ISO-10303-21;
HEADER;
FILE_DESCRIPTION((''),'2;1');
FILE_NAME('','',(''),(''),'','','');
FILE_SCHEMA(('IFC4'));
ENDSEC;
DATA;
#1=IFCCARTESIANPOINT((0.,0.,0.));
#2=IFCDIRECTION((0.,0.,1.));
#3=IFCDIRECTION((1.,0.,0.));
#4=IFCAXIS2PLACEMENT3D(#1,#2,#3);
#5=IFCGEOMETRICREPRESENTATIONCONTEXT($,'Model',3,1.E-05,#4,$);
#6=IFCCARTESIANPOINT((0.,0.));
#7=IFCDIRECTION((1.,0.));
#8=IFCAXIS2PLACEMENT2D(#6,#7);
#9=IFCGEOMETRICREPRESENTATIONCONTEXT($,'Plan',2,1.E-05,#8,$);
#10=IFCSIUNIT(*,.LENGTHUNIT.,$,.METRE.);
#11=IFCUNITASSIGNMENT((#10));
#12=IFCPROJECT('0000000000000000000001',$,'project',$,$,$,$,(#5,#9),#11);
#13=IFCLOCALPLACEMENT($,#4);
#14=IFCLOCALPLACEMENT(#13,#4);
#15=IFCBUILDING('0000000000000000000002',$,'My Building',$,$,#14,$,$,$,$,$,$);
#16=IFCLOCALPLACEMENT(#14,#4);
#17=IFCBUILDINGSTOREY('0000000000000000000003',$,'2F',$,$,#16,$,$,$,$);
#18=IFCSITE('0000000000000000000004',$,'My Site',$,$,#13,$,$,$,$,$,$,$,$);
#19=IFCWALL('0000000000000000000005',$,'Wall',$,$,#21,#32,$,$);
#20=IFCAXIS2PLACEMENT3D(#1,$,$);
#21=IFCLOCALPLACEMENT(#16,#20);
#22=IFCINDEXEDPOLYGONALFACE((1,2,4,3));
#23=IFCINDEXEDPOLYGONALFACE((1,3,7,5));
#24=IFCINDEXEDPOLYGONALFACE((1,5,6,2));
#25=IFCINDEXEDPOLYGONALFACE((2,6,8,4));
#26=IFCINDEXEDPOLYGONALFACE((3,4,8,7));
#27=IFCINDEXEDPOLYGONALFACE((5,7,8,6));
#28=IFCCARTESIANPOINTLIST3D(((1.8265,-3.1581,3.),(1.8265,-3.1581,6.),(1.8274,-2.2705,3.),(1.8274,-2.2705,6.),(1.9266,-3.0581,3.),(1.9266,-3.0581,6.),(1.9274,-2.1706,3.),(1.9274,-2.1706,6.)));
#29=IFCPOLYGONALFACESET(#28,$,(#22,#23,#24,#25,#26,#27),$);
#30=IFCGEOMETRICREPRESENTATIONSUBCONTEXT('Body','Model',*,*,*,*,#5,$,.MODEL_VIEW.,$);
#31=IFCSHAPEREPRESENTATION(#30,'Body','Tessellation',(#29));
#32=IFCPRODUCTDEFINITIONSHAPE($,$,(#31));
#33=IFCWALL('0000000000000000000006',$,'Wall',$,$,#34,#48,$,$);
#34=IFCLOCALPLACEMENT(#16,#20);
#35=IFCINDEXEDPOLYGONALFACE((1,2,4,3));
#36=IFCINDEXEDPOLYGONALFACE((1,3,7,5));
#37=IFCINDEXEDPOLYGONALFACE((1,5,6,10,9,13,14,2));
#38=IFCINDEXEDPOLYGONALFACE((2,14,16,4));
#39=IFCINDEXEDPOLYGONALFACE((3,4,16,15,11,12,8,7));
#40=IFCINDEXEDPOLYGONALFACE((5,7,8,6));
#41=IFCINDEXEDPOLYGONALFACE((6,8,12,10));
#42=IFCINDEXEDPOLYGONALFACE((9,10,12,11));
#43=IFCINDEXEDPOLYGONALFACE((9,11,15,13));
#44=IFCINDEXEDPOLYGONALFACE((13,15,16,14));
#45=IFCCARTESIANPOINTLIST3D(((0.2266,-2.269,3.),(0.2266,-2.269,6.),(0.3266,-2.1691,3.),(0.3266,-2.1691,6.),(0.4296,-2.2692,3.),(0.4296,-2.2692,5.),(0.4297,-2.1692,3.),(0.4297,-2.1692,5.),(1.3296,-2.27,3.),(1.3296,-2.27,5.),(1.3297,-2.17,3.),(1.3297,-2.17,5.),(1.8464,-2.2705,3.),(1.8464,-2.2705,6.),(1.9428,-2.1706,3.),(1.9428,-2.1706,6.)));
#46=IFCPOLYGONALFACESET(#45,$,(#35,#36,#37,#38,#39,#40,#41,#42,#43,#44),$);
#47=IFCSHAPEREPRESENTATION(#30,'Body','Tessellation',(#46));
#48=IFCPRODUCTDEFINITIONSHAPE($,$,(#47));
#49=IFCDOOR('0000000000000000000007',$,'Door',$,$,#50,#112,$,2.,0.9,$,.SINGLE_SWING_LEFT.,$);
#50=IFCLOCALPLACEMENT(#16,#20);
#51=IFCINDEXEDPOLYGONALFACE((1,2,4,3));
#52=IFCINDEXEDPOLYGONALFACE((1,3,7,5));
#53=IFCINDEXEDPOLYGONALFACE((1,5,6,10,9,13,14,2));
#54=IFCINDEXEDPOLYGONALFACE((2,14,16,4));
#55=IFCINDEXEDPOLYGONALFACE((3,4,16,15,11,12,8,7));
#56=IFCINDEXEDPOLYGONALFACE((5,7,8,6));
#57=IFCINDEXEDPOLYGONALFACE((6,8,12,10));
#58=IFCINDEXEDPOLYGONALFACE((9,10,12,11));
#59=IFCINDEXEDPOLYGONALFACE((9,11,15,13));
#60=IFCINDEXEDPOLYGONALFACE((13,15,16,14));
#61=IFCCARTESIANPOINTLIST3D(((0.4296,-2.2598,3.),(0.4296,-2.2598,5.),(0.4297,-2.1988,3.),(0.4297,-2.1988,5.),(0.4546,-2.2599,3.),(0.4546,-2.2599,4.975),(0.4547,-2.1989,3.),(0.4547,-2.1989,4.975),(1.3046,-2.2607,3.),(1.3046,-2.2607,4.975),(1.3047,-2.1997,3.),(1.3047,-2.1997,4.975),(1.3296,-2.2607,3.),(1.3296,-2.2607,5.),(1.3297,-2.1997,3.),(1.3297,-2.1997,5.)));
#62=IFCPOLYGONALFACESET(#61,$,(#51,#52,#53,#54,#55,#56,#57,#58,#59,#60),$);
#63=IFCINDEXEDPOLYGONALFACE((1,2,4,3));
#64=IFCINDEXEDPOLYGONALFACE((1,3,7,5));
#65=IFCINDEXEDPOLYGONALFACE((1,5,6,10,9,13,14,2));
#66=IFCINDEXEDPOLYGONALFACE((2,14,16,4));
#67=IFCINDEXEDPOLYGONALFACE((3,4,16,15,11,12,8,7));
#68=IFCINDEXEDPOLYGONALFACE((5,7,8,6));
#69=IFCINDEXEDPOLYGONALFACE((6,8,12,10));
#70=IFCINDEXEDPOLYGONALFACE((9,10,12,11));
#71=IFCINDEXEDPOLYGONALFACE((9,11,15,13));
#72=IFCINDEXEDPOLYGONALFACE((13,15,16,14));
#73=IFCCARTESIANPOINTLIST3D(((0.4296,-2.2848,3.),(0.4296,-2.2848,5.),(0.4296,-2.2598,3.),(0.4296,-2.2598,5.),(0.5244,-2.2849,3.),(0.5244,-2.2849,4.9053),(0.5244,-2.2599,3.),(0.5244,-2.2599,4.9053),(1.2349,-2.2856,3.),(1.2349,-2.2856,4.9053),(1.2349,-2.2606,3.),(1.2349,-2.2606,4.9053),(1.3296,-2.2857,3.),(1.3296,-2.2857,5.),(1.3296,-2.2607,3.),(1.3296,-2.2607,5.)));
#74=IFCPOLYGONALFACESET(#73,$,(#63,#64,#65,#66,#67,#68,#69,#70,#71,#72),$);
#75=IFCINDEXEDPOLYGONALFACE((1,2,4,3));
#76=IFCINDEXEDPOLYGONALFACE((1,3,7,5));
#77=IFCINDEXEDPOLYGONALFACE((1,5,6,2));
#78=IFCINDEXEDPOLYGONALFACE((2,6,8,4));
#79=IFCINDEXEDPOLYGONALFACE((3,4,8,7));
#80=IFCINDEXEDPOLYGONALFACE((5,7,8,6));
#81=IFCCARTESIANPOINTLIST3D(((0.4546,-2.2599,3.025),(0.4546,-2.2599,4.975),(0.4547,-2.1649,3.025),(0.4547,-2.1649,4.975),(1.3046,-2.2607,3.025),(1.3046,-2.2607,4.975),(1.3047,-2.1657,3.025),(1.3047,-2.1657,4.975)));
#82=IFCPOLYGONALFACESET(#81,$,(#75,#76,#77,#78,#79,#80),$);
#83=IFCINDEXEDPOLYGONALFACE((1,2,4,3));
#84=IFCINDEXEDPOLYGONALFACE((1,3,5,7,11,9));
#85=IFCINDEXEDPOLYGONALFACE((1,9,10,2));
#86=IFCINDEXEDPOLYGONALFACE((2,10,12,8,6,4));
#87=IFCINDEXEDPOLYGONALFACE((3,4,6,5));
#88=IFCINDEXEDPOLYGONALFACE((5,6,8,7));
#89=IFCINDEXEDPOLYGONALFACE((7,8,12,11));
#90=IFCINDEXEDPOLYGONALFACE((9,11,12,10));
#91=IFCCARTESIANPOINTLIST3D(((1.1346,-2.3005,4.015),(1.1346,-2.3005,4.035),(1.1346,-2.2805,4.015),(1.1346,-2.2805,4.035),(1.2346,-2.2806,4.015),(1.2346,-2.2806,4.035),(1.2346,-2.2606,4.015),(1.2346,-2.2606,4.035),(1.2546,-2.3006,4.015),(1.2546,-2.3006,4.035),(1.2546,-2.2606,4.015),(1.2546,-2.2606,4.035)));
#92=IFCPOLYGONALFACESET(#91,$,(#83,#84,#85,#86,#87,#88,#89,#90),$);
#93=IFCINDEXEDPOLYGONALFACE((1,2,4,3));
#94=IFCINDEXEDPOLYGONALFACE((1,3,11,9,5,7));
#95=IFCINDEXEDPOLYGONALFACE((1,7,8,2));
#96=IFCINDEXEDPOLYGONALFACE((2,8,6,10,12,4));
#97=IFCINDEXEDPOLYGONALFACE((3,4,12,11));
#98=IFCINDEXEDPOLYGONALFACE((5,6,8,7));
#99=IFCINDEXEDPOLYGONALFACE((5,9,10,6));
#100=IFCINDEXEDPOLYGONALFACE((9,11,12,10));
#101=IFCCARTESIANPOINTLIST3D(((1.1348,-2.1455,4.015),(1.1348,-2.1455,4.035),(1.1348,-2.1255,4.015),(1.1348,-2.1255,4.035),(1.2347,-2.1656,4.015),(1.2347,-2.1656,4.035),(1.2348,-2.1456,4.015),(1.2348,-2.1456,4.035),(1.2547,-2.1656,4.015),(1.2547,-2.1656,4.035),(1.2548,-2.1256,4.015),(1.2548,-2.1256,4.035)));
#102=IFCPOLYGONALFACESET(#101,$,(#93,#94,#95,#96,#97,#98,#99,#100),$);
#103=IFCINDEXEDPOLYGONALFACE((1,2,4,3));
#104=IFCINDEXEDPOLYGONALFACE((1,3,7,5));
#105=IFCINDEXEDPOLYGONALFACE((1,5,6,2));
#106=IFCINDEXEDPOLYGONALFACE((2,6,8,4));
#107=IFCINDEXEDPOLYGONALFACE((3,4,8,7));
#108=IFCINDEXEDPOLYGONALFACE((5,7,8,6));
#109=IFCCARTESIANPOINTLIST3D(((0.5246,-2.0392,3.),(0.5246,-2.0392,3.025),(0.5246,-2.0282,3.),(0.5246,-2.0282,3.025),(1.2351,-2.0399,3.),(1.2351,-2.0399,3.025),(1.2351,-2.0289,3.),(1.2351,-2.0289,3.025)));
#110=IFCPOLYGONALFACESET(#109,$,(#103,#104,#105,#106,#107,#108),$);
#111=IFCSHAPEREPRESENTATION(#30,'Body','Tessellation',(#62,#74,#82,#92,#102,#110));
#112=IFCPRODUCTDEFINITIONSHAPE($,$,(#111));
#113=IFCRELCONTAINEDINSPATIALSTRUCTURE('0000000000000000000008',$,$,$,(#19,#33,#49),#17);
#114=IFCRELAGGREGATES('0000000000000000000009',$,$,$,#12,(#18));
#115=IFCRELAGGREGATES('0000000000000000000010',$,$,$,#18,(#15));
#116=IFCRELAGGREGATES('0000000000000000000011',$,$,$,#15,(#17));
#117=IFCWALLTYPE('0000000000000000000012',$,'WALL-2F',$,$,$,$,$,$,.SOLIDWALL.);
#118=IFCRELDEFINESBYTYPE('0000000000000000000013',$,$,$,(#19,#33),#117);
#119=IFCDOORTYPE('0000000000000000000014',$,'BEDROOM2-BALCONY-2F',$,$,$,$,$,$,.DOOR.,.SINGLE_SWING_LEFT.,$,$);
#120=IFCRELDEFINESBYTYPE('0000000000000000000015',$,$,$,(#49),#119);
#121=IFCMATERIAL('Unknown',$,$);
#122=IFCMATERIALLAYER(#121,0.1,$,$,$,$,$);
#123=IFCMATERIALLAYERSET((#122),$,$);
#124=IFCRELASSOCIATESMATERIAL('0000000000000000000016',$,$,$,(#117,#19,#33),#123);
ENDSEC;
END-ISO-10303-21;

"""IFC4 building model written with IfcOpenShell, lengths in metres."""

from ifc_helpers import new_model, entity, si_unit, frame, origin_with_axes, origin_2d_with_axis, place, context, subcontext, project, spatial, line, indexed_curve, outline, extrude, shape, source, transform, mapped, material, layer, layer_set, layer_usage, type_object, type_shapes, element, fill, save


model = new_model("IFC4")

# Units and contexts
model_context = context("Model", 3, precision=1e-05, world=origin_with_axes())
plan_context = context("Plan", 2, precision=1e-05, world=origin_2d_with_axis())
body_context_1 = subcontext(model_context, "Body", "Model", "MODEL_VIEW")
body_context_2 = subcontext(plan_context, "Body", "Plan", "PLAN_VIEW")
ifc_project = project(units=[si_unit("LENGTHUNIT", "METRE")], contexts=[model_context, plan_context])

# Site, building, storey
site_placement = place(None, origin_with_axes())
site = spatial("IfcSite", under=ifc_project, at=site_placement, Name="My Site")
building_placement = place(site_placement, origin_with_axes())
building = spatial("IfcBuilding", under=site, at=building_placement, Name="My Building")
storey_placement = place(building_placement, origin_with_axes())
storey = spatial("IfcBuildingStorey", under=building, at=storey_placement, Name="2F")

# Shared definitions
ifc_material = material(Name="Unknown")
ifc_layer_1 = layer(ifc_material, 0.1)
ifc_layer_set_1 = layer_set([ifc_layer_1])
wall_type_1 = type_object("IfcWallType", Name="WALL-2F", PredefinedType="SOLIDWALL", material=ifc_layer_set_1)

# Wall
ifc_layer_usage_1 = layer_usage(ifc_layer_set_1, "AXIS2", "POSITIVE", 0.0)
wall_1_placement = place(storey_placement, frame((1.9266, -3.0581, 3.0), z_axis=(0.0, 0.0, 1.0), x_axis=(0.000947, 1.0, 0.0)))
element("IfcWall", 1, at=wall_1_placement, inside=storey, type_object=wall_type_1, material=ifc_layer_usage_1, Name="Wall", context=body_context_1, shape_type="SweptSolid", body=[
    extrude(outline(indexed_curve([(0.0, 0.0), (-0.1001, 0.1), (0.7875, 0.1), (0.8875, 0.0)], segments=[line(1, 2, 3, 4, 1)])), origin_with_axes(), (0.0, 0.0, 1.0), 3.0),
])

# Wall, opening, door
ifc_layer_usage_2 = layer_usage(ifc_layer_set_1, "AXIS2", "POSITIVE", 0.0)
wall_2_placement = place(storey_placement, frame((1.9428, -2.1706, 3.0), z_axis=(0.0, 0.0, 1.0), x_axis=(-1.0, 0.000946, 0.0)))
wall_2 = element("IfcWall", 2, at=wall_2_placement, inside=storey, type_object=wall_type_1, material=ifc_layer_usage_2, Name="Wall", context=body_context_1, shape_type="SweptSolid", body=[
    extrude(outline(indexed_curve([(0.0, 0.0), (0.0963, 0.1), (1.7161, 0.1), (1.6162, 0.0)], segments=[line(1, 2, 3, 4, 1)])), origin_with_axes(), (0.0, 0.0, 1.0), 3.0),
])
shared_shape_1 = source(origin_with_axes(), body_context_1, "Body", "SweptSolid", [
    extrude(outline(indexed_curve([(0.0, 0.0), (0.9, 0.0), (0.9, 2.0), (0.0, 2.0)], segments=[line(1, 2, 3, 4, 1)])), frame((0.0, -0.6, 0.0), z_axis=(0.0, -1.0, 0.0), x_axis=(1.0, 0.0, 0.0)), (0.0, 0.0, -1.0), 1.2),
])
opening_1_placement = place(wall_2_placement, frame((1.513, 0.1, 0.0), z_axis=(0.0, 0.0, 1.0), x_axis=(-1.0, 0.0, 0.0)))
opening_1 = element("IfcOpeningElement", 3, at=opening_1_placement, cuts=wall_2, PredefinedType="OPENING", context=body_context_1, shape_type="MappedRepresentation", body=[
    mapped(shared_shape_1, transform((0.0, 0.0, 0.0), x_axis=(1.0, 0.0, 0.0), y_axis=(0.0, 1.0, 0.0), z_axis=(0.0, 0.0, 1.0), scale=1.0)),
])
door_type_1 = type_object("IfcDoorType", Name="BEDROOM2-BALCONY-2F", OperationType="SINGLE_SWING_LEFT", PredefinedType="DOOR")
shared_shape_2 = source(origin_with_axes(), body_context_1, "Body", "SweptSolid", [
    extrude(outline(indexed_curve([(0.0, 0.0), (0.0, 2.0), (0.9, 2.0), (0.9, 0.0), (0.875, 0.0), (0.875, 1.975), (0.025, 1.975), (0.025, 0.0)], segments=[line(1, 2, 3, 4, 5, 6, 7, 8, 1)])), frame((0.0, 0.0093, 0.0), z_axis=(0.0, -1.0, 0.0), x_axis=(1.0, 0.0, 0.0)), (0.0, 0.0, -1.0), 0.061),
    extrude(outline(indexed_curve([(0.0, 0.0), (0.0, 2.0), (0.9, 2.0), (0.9, 0.0), (0.8053, 0.0), (0.8053, 1.9053), (0.0947, 1.9053), (0.0947, 0.0)], segments=[line(1, 2, 3, 4, 5, 6, 7, 8, 1)])), frame((0.0, -0.0157, 0.0), z_axis=(0.0, -1.0, 0.0), x_axis=(1.0, 0.0, 0.0)), (0.0, 0.0, -1.0), 0.025),
    extrude(outline(indexed_curve([(0.0, 0.0), (0.85, 0.0), (0.85, 0.095), (0.0, 0.095)], segments=[line(1, 2, 3, 4, 1)])), frame((0.025, 0.0093, 0.025), z_axis=(0.0, 0.0, 1.0), x_axis=(1.0, 0.0, 0.0)), (0.0, 0.0, 1.0), 1.95),
    extrude(outline(indexed_curve([(0.0, 0.0), (0.0, -0.04), (-0.12, -0.04), (-0.12, -0.02), (-0.02, -0.02), (-0.02, 0.0)], segments=[line(1, 2, 3, 4, 5, 6, 1)])), frame((0.825, 0.0093, 1.015), z_axis=(0.0, 0.0, 1.0), x_axis=(1.0, 0.0, 0.0)), (0.0, 0.0, 1.0), 0.02),
    extrude(outline(indexed_curve([(0.0, 0.0), (0.0, 0.04), (-0.12, 0.04), (-0.12, 0.02), (-0.02, 0.02), (-0.02, 0.0)], segments=[line(1, 2, 3, 4, 5, 6, 1)])), frame((0.825, 0.1043, 1.015), z_axis=(0.0, 0.0, 1.0), x_axis=(1.0, 0.0, 0.0)), (0.0, 0.0, 1.0), 0.02),
    extrude(outline(indexed_curve([(0.0, 0.0), (0.7105, 0.0), (0.7105, 0.011), (0.0, 0.011)], segments=[line(1, 2, 3, 4, 1)])), frame((0.0947, 0.23, 0.0), z_axis=(0.0, 0.0, 1.0), x_axis=(1.0, 0.0, 0.0)), (0.0, 0.0, 1.0), 0.025),
])
shared_shape_3 = source(origin_with_axes(), body_context_2, "Body", "Curve2D", [
    entity("IfcIndexedPolyCurve", entity("IfcCartesianPointList2D", [[0.0, -0.0157], [0.0, 0.0703], [0.025, 0.0703], [0.025, 0.0093], [0.0947, 0.0093], [0.0947, -0.0157]]), [entity("IfcLineIndex", [1, 2, 3, 4, 5, 6, 1])]),
    entity("IfcIndexedPolyCurve", entity("IfcCartesianPointList2D", [[0.9, -0.0157], [0.9, 0.0703], [0.875, 0.0703], [0.875, 0.0093], [0.8053, 0.0093], [0.8053, -0.0157]]), [entity("IfcLineIndex", [1, 2, 3, 4, 5, 6, 1])]),
    entity("IfcTrimmedCurve", entity("IfcEllipse", entity("IfcAxis2Placement2D", entity("IfcCartesianPoint", [0.12, 0.0703]), entity("IfcDirection", [1.0, 0.0])), 0.755, 0.85), [entity("IfcCartesianPoint", [0.875, 0.0703])], [entity("IfcCartesianPoint", [0.12, 0.9203])], True, "CARTESIAN"),
    entity("IfcIndexedPolyCurve", entity("IfcCartesianPointList2D", [[0.025, 0.0703], [0.12, 0.0703], [0.12, 0.9203], [0.025, 0.9203]]), [entity("IfcLineIndex", [1, 2, 3, 4, 1])]),
])
type_shapes(door_type_1, [shared_shape_2, shared_shape_3])
door_1_placement = place(opening_1_placement, frame((0.0, 0.0, 0.0), z_axis=(0.0, 0.0, 1.0), x_axis=(1.0, 0.0, 0.0)))
door_1 = element("IfcDoor", 4, at=door_1_placement, inside=storey, type_object=door_type_1, Name="Door", OperationType="SINGLE_SWING_LEFT", OverallHeight=2.0, OverallWidth=0.9, shapes=[
    shape(body_context_1, "Body", "MappedRepresentation", [mapped(shared_shape_2, transform((0.0, 0.0, 0.0), x_axis=(1.0, 0.0, 0.0), y_axis=(0.0, 1.0, 0.0), z_axis=(0.0, 0.0, 1.0), scale=1.0))]),
    shape(body_context_2, "Body", "MappedRepresentation", [mapped(shared_shape_3, transform((0.0, 0.0, 0.0), x_axis=(1.0, 0.0, 0.0), y_axis=(0.0, 1.0, 0.0), z_axis=(0.0, 0.0, 1.0), scale=1.0))]),
])
fill(opening_1, door_1)

save(model, "model.ifc")
